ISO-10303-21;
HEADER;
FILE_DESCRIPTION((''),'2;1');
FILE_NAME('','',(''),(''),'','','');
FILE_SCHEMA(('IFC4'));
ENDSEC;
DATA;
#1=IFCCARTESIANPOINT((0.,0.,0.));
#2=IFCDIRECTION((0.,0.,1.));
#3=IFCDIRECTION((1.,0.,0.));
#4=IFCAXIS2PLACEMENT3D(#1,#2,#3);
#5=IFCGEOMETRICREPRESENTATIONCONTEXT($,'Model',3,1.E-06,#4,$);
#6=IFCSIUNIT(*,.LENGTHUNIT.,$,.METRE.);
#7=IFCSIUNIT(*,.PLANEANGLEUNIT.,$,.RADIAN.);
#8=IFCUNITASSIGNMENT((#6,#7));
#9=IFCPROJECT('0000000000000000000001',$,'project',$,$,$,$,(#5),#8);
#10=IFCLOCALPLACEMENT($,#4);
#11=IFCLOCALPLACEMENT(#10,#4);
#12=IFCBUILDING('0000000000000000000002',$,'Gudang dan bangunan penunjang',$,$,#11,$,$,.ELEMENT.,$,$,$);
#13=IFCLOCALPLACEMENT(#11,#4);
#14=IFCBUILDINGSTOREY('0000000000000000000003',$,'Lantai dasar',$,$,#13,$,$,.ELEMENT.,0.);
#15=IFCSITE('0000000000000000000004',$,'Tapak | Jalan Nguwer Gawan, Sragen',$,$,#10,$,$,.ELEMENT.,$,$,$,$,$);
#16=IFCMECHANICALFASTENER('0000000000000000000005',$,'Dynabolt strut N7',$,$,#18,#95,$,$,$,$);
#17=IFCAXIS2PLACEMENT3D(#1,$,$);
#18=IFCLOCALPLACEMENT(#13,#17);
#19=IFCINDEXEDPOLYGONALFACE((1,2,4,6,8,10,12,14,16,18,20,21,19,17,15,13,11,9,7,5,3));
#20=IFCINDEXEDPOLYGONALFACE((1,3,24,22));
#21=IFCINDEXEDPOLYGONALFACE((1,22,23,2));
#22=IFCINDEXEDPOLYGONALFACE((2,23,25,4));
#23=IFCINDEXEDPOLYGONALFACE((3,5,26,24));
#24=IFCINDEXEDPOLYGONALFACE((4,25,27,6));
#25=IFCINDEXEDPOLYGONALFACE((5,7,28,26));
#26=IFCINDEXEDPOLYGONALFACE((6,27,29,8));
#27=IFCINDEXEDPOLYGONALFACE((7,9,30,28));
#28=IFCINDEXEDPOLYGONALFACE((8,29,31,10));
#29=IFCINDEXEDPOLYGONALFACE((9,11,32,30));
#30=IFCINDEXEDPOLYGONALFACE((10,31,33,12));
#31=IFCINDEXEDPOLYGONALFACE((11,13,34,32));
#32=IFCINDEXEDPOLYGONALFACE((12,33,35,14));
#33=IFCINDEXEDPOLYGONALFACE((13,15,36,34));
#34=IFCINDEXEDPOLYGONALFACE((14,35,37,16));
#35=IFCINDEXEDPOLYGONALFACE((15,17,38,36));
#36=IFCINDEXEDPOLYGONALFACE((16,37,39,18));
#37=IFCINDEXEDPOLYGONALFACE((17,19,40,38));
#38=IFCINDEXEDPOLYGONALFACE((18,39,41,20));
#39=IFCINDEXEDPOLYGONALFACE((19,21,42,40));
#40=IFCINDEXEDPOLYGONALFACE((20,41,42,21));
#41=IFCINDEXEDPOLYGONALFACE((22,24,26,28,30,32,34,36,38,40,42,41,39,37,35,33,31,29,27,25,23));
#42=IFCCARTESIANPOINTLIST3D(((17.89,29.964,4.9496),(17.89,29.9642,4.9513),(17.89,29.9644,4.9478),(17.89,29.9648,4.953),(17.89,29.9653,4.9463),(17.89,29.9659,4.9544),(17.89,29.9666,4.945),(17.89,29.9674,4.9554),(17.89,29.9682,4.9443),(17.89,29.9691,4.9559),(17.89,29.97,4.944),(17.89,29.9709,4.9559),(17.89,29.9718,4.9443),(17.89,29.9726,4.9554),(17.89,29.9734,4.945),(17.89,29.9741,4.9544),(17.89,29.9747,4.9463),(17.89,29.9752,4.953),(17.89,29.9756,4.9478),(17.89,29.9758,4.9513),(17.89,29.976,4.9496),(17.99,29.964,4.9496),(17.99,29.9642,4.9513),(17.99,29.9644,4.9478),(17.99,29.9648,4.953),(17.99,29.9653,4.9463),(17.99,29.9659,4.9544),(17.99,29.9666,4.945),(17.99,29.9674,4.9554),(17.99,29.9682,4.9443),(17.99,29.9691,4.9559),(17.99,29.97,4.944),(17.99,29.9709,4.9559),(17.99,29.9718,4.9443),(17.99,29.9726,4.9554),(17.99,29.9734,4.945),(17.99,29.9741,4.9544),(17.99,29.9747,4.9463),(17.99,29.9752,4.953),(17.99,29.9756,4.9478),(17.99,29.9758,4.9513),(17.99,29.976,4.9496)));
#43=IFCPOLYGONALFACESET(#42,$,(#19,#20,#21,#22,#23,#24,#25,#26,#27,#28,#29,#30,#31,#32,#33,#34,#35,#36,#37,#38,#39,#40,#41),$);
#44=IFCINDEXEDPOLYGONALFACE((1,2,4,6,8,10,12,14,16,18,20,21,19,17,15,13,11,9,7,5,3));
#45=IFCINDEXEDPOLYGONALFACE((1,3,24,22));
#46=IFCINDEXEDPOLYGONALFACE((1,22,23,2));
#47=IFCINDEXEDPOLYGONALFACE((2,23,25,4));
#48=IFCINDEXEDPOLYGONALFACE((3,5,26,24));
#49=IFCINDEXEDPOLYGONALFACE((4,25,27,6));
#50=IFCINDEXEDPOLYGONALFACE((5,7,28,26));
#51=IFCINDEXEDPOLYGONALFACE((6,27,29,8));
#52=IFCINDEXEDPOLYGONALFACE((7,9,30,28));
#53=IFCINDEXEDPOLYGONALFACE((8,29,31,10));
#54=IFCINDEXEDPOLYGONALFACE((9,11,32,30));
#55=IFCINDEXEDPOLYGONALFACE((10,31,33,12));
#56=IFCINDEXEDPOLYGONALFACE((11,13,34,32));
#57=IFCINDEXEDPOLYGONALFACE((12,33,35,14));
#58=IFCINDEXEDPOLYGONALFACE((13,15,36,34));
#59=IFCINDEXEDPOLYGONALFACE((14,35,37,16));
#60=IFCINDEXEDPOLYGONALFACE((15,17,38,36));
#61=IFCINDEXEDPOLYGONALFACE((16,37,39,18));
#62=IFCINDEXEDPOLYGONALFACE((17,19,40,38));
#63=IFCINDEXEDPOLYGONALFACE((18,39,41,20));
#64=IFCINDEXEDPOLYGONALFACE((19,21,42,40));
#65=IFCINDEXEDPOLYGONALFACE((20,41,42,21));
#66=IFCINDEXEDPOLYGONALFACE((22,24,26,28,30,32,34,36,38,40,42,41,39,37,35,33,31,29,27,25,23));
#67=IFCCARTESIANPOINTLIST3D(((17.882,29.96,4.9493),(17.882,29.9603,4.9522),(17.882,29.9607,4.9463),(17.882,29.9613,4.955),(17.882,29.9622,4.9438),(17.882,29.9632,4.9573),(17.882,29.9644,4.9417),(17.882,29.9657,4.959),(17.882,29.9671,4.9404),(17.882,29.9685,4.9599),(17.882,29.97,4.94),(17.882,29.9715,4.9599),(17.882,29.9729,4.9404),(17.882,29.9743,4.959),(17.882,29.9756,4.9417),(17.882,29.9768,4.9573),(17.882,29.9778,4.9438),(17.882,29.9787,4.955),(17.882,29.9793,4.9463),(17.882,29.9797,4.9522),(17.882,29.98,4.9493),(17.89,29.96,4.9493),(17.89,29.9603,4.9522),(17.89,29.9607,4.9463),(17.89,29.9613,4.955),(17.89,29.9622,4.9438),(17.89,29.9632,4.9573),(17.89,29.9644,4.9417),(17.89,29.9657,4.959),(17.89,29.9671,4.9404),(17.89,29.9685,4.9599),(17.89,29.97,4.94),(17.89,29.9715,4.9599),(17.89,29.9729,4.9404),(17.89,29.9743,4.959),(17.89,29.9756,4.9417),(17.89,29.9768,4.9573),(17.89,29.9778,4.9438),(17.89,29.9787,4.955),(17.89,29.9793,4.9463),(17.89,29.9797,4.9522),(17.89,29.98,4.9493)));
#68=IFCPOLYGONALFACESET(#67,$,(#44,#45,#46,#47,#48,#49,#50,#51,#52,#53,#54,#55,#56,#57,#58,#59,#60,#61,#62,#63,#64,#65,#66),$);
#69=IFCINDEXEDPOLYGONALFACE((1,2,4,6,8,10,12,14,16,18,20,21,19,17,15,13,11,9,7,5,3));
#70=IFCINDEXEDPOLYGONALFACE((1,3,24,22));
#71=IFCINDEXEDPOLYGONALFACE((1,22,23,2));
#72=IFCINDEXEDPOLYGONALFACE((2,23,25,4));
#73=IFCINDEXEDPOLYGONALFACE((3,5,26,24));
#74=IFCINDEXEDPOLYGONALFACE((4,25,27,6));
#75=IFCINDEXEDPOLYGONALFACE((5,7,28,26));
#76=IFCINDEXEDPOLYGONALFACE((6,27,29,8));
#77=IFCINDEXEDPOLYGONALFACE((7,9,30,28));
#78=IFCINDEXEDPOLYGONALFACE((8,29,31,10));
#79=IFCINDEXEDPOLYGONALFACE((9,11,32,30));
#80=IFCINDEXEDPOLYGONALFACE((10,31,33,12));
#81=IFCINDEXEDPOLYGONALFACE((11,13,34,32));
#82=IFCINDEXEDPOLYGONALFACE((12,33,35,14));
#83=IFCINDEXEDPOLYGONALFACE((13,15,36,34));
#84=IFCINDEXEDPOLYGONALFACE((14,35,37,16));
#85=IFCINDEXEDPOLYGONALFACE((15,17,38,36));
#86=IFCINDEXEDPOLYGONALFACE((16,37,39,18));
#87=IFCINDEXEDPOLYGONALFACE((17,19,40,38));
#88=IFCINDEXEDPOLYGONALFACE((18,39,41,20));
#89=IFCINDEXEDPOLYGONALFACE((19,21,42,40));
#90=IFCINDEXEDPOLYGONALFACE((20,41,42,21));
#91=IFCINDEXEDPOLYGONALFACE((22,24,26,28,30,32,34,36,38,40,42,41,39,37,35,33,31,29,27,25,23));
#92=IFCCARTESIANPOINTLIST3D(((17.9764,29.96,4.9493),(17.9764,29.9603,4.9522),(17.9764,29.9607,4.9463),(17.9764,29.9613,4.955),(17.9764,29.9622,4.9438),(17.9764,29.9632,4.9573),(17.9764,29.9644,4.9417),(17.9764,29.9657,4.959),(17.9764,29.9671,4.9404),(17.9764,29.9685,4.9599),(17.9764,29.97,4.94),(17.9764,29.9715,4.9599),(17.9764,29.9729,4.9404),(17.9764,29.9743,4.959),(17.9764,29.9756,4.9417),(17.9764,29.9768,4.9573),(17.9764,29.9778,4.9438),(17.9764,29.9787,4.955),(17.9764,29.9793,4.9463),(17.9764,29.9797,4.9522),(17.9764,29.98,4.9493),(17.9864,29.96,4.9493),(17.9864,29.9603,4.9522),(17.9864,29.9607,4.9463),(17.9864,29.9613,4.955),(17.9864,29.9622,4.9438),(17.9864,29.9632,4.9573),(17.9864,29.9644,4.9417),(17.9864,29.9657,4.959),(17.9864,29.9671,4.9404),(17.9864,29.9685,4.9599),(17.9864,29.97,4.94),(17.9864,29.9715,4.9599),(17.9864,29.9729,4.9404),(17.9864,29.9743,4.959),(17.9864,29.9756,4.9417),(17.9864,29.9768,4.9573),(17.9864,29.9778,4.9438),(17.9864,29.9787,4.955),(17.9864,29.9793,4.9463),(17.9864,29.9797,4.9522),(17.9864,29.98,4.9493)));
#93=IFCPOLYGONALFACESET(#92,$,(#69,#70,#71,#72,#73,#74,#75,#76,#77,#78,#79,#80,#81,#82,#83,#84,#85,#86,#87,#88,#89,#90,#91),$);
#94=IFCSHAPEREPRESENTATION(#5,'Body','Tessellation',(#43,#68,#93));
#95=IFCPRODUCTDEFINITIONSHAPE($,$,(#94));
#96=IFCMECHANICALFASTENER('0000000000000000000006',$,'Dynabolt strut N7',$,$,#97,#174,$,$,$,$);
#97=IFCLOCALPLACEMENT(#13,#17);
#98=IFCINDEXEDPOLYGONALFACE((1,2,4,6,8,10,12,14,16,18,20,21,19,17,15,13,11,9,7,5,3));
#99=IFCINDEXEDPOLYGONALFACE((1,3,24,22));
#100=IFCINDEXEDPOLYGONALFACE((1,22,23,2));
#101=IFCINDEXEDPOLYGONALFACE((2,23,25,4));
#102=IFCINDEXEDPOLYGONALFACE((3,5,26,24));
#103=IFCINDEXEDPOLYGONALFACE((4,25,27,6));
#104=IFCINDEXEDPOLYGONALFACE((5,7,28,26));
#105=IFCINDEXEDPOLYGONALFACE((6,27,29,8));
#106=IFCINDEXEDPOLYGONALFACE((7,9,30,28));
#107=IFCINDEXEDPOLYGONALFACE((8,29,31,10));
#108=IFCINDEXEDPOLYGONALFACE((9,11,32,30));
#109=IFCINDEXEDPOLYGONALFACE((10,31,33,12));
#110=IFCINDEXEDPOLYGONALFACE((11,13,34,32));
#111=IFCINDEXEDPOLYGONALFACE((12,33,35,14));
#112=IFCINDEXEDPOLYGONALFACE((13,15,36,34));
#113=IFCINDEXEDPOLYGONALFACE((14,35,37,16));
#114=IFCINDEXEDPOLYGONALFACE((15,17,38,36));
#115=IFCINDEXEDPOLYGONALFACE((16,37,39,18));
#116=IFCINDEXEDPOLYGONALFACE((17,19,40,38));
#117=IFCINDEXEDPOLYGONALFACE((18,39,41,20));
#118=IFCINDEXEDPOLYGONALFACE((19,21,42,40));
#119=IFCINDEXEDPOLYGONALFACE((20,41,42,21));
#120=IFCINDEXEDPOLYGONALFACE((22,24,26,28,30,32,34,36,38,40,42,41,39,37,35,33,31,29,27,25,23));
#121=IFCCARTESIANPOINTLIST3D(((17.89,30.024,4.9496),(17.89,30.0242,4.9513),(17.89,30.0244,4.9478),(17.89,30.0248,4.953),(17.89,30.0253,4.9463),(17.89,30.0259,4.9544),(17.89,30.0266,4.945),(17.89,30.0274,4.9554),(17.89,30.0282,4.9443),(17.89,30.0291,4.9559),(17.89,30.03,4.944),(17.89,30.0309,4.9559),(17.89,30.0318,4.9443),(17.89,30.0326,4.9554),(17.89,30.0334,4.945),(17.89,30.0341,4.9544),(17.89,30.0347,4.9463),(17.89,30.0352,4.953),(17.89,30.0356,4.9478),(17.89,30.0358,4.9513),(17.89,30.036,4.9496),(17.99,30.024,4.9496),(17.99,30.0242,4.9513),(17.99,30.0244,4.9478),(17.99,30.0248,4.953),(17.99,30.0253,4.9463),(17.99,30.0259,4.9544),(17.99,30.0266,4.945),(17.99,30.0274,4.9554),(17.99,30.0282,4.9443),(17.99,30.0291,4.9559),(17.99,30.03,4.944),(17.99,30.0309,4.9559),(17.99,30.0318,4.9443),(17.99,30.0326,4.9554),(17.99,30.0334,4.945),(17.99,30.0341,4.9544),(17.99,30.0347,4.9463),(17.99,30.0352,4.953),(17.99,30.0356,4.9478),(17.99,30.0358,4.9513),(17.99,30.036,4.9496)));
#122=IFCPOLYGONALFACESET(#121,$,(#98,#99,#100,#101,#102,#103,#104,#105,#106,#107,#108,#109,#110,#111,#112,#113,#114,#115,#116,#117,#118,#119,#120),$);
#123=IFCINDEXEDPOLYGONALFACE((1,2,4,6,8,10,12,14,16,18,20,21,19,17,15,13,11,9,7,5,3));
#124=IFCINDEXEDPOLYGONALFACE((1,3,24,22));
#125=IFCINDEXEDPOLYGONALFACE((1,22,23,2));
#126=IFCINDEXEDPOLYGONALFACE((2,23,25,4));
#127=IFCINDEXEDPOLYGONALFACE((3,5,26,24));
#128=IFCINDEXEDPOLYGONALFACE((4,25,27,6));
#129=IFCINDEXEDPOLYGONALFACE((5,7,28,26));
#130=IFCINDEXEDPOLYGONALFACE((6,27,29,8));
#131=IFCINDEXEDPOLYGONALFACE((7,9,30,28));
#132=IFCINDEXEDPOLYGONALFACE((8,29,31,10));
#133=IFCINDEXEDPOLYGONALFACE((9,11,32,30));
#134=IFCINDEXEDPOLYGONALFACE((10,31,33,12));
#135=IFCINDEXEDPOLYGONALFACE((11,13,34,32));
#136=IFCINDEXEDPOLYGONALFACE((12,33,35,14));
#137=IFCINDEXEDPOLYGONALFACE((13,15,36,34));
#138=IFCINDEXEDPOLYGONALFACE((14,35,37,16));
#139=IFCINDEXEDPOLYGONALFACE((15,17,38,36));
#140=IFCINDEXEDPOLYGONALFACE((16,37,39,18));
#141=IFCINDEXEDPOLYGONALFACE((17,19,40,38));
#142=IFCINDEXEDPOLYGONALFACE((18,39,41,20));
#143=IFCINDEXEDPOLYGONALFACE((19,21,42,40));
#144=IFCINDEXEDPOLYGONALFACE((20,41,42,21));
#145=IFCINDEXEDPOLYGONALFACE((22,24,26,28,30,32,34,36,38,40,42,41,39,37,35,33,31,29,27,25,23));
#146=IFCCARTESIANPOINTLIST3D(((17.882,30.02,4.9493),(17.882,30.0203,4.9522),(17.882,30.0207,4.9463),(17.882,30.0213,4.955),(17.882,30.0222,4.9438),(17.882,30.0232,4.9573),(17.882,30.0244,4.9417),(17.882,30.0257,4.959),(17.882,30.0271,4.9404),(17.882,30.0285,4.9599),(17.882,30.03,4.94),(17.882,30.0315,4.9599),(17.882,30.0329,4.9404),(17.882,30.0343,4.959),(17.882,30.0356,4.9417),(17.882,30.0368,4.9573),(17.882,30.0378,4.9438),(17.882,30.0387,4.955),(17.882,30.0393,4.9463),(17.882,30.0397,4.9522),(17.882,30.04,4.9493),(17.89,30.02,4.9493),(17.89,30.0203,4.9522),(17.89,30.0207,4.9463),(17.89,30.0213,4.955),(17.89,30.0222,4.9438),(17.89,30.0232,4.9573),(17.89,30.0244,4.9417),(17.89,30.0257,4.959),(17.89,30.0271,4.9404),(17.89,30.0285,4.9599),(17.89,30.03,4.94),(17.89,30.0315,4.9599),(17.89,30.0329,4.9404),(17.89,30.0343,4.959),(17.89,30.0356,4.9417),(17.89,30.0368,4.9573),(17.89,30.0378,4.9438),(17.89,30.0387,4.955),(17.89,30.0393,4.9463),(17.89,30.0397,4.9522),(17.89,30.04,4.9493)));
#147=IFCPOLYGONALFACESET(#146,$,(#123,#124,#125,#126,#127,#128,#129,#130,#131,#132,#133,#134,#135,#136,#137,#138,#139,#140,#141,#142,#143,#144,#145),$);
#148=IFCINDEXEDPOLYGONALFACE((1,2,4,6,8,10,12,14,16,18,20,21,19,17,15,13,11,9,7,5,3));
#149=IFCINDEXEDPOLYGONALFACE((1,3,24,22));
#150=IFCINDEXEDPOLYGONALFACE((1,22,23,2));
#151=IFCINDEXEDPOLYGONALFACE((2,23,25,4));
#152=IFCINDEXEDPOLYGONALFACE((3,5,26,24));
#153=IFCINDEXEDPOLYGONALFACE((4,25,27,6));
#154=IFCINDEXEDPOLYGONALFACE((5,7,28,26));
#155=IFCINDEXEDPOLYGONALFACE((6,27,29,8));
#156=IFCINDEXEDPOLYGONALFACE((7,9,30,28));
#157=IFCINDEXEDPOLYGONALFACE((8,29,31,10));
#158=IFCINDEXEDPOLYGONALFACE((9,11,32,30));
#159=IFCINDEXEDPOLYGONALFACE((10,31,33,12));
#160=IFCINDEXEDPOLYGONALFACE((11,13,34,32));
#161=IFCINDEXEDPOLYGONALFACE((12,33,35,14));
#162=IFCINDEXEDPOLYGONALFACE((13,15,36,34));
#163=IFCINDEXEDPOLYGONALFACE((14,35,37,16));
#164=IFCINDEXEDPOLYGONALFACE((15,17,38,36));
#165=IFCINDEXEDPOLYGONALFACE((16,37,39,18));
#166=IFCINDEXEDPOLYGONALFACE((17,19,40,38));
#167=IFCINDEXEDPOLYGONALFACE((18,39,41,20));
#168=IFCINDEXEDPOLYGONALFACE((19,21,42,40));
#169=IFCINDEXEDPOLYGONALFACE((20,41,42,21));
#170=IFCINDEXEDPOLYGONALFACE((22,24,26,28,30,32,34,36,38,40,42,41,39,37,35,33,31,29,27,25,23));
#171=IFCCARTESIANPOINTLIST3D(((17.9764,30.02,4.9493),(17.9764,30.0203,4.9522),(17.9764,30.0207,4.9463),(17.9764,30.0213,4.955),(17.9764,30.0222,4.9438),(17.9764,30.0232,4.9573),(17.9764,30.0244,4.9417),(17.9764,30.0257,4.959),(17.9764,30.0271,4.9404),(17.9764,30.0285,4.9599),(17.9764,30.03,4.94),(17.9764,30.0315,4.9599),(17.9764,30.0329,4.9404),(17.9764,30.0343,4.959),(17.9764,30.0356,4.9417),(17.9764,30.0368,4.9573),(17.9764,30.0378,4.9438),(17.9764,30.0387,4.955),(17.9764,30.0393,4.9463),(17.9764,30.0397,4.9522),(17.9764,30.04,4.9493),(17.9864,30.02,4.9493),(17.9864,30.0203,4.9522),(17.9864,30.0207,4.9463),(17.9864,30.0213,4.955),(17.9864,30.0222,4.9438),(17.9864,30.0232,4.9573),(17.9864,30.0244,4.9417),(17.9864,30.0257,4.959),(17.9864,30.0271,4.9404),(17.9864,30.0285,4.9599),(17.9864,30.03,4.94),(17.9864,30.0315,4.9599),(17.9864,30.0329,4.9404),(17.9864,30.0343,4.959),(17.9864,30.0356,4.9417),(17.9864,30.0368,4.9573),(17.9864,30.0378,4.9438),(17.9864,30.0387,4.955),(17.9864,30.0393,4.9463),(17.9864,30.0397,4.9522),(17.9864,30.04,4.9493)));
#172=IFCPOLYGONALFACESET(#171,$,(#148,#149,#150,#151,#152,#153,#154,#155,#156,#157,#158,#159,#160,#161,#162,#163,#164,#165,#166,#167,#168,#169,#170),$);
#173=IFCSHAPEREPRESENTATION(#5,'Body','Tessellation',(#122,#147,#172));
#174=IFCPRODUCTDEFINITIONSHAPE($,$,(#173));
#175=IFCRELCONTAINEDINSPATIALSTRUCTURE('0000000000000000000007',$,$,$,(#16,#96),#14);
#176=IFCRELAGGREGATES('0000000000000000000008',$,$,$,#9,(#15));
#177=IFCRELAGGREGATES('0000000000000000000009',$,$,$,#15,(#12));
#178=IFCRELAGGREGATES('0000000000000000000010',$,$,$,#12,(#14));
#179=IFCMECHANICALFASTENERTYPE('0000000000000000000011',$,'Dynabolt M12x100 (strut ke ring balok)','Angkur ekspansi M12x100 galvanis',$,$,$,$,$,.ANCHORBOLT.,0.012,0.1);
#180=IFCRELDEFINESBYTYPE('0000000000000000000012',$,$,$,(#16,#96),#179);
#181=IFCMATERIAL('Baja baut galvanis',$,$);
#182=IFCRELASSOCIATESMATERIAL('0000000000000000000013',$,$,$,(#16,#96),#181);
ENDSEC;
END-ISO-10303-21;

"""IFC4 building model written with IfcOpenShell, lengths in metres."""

from ifc_helpers import new_model, si_unit, frame, origin_with_axes, place, context, project, spatial, circle, extrude, source, transform, mapped, material, type_object, type_shapes, element, save


model = new_model("IFC4")

# Units and contexts
model_context = context("Model", 3, precision=1e-06, world=origin_with_axes())
ifc_project = project(units=[si_unit("LENGTHUNIT", "METRE"), si_unit("PLANEANGLEUNIT", "RADIAN")], contexts=[model_context])

# Site, building, storey
site_placement = place(None, origin_with_axes())
site = spatial("IfcSite", under=ifc_project, at=site_placement, Name="Tapak | Jalan Nguwer Gawan, Sragen", CompositionType="ELEMENT")
building_placement = place(site_placement, origin_with_axes())
building = spatial("IfcBuilding", under=site, at=building_placement, Name="Gudang dan bangunan penunjang", CompositionType="ELEMENT")
storey_placement = place(building_placement, origin_with_axes())
storey = spatial("IfcBuildingStorey", under=building, at=storey_placement, Name="Lantai dasar", CompositionType="ELEMENT", Elevation=0.0)

# Mechanical fasteners
ifc_material = material(Name="Baja baut galvanis")
mechanical_fastener_type = type_object("IfcMechanicalFastenerType", Name="Dynabolt M12x100 (strut ke ring balok)", Description="Angkur ekspansi M12x100 galvanis", NominalDiameter=0.012, NominalLength=0.1, PredefinedType="ANCHORBOLT")
shared_shape = source(origin_with_axes(), model_context, "Body", "SweptSolid", [
    extrude(circle(Radius=0.006), origin_with_axes(), (0.0, 0.0, 1.0), 0.1),
    extrude(circle(Radius=0.01), frame((0.0, 0.0, -0.008), z_axis=(0.0, 0.0, 1.0), x_axis=(1.0, 0.0, 0.0)), (0.0, 0.0, 1.0), 0.008),
    extrude(circle(Radius=0.01), frame((0.0, 0.0, 0.0864), z_axis=(0.0, 0.0, 1.0), x_axis=(1.0, 0.0, 0.0)), (0.0, 0.0, 1.0), 0.01),
])
type_shapes(mechanical_fastener_type, [shared_shape])
placement = place(None, origin_with_axes())
element("IfcMechanicalFastener", 1, at=placement, inside=storey, type_object=mechanical_fastener_type, material=ifc_material, Name="Dynabolt strut N7", context=model_context, shape_type="MappedRepresentation", body=[
    mapped(shared_shape, transform((17.89, 29.97, 4.95), x_axis=(0.0, 0.0, -1.0), y_axis=(0.0, 1.0, 0.0), z_axis=(1.0, 0.0, 0.0), scale=1.0)),
])
element("IfcMechanicalFastener", 2, at=placement, inside=storey, type_object=mechanical_fastener_type, material=ifc_material, Name="Dynabolt strut N7", context=model_context, shape_type="MappedRepresentation", body=[
    mapped(shared_shape, transform((17.89, 30.03, 4.95), x_axis=(0.0, 0.0, -1.0), y_axis=(0.0, 1.0, 0.0), z_axis=(1.0, 0.0, 0.0), scale=1.0)),
])

save(model, "model.ifc")
